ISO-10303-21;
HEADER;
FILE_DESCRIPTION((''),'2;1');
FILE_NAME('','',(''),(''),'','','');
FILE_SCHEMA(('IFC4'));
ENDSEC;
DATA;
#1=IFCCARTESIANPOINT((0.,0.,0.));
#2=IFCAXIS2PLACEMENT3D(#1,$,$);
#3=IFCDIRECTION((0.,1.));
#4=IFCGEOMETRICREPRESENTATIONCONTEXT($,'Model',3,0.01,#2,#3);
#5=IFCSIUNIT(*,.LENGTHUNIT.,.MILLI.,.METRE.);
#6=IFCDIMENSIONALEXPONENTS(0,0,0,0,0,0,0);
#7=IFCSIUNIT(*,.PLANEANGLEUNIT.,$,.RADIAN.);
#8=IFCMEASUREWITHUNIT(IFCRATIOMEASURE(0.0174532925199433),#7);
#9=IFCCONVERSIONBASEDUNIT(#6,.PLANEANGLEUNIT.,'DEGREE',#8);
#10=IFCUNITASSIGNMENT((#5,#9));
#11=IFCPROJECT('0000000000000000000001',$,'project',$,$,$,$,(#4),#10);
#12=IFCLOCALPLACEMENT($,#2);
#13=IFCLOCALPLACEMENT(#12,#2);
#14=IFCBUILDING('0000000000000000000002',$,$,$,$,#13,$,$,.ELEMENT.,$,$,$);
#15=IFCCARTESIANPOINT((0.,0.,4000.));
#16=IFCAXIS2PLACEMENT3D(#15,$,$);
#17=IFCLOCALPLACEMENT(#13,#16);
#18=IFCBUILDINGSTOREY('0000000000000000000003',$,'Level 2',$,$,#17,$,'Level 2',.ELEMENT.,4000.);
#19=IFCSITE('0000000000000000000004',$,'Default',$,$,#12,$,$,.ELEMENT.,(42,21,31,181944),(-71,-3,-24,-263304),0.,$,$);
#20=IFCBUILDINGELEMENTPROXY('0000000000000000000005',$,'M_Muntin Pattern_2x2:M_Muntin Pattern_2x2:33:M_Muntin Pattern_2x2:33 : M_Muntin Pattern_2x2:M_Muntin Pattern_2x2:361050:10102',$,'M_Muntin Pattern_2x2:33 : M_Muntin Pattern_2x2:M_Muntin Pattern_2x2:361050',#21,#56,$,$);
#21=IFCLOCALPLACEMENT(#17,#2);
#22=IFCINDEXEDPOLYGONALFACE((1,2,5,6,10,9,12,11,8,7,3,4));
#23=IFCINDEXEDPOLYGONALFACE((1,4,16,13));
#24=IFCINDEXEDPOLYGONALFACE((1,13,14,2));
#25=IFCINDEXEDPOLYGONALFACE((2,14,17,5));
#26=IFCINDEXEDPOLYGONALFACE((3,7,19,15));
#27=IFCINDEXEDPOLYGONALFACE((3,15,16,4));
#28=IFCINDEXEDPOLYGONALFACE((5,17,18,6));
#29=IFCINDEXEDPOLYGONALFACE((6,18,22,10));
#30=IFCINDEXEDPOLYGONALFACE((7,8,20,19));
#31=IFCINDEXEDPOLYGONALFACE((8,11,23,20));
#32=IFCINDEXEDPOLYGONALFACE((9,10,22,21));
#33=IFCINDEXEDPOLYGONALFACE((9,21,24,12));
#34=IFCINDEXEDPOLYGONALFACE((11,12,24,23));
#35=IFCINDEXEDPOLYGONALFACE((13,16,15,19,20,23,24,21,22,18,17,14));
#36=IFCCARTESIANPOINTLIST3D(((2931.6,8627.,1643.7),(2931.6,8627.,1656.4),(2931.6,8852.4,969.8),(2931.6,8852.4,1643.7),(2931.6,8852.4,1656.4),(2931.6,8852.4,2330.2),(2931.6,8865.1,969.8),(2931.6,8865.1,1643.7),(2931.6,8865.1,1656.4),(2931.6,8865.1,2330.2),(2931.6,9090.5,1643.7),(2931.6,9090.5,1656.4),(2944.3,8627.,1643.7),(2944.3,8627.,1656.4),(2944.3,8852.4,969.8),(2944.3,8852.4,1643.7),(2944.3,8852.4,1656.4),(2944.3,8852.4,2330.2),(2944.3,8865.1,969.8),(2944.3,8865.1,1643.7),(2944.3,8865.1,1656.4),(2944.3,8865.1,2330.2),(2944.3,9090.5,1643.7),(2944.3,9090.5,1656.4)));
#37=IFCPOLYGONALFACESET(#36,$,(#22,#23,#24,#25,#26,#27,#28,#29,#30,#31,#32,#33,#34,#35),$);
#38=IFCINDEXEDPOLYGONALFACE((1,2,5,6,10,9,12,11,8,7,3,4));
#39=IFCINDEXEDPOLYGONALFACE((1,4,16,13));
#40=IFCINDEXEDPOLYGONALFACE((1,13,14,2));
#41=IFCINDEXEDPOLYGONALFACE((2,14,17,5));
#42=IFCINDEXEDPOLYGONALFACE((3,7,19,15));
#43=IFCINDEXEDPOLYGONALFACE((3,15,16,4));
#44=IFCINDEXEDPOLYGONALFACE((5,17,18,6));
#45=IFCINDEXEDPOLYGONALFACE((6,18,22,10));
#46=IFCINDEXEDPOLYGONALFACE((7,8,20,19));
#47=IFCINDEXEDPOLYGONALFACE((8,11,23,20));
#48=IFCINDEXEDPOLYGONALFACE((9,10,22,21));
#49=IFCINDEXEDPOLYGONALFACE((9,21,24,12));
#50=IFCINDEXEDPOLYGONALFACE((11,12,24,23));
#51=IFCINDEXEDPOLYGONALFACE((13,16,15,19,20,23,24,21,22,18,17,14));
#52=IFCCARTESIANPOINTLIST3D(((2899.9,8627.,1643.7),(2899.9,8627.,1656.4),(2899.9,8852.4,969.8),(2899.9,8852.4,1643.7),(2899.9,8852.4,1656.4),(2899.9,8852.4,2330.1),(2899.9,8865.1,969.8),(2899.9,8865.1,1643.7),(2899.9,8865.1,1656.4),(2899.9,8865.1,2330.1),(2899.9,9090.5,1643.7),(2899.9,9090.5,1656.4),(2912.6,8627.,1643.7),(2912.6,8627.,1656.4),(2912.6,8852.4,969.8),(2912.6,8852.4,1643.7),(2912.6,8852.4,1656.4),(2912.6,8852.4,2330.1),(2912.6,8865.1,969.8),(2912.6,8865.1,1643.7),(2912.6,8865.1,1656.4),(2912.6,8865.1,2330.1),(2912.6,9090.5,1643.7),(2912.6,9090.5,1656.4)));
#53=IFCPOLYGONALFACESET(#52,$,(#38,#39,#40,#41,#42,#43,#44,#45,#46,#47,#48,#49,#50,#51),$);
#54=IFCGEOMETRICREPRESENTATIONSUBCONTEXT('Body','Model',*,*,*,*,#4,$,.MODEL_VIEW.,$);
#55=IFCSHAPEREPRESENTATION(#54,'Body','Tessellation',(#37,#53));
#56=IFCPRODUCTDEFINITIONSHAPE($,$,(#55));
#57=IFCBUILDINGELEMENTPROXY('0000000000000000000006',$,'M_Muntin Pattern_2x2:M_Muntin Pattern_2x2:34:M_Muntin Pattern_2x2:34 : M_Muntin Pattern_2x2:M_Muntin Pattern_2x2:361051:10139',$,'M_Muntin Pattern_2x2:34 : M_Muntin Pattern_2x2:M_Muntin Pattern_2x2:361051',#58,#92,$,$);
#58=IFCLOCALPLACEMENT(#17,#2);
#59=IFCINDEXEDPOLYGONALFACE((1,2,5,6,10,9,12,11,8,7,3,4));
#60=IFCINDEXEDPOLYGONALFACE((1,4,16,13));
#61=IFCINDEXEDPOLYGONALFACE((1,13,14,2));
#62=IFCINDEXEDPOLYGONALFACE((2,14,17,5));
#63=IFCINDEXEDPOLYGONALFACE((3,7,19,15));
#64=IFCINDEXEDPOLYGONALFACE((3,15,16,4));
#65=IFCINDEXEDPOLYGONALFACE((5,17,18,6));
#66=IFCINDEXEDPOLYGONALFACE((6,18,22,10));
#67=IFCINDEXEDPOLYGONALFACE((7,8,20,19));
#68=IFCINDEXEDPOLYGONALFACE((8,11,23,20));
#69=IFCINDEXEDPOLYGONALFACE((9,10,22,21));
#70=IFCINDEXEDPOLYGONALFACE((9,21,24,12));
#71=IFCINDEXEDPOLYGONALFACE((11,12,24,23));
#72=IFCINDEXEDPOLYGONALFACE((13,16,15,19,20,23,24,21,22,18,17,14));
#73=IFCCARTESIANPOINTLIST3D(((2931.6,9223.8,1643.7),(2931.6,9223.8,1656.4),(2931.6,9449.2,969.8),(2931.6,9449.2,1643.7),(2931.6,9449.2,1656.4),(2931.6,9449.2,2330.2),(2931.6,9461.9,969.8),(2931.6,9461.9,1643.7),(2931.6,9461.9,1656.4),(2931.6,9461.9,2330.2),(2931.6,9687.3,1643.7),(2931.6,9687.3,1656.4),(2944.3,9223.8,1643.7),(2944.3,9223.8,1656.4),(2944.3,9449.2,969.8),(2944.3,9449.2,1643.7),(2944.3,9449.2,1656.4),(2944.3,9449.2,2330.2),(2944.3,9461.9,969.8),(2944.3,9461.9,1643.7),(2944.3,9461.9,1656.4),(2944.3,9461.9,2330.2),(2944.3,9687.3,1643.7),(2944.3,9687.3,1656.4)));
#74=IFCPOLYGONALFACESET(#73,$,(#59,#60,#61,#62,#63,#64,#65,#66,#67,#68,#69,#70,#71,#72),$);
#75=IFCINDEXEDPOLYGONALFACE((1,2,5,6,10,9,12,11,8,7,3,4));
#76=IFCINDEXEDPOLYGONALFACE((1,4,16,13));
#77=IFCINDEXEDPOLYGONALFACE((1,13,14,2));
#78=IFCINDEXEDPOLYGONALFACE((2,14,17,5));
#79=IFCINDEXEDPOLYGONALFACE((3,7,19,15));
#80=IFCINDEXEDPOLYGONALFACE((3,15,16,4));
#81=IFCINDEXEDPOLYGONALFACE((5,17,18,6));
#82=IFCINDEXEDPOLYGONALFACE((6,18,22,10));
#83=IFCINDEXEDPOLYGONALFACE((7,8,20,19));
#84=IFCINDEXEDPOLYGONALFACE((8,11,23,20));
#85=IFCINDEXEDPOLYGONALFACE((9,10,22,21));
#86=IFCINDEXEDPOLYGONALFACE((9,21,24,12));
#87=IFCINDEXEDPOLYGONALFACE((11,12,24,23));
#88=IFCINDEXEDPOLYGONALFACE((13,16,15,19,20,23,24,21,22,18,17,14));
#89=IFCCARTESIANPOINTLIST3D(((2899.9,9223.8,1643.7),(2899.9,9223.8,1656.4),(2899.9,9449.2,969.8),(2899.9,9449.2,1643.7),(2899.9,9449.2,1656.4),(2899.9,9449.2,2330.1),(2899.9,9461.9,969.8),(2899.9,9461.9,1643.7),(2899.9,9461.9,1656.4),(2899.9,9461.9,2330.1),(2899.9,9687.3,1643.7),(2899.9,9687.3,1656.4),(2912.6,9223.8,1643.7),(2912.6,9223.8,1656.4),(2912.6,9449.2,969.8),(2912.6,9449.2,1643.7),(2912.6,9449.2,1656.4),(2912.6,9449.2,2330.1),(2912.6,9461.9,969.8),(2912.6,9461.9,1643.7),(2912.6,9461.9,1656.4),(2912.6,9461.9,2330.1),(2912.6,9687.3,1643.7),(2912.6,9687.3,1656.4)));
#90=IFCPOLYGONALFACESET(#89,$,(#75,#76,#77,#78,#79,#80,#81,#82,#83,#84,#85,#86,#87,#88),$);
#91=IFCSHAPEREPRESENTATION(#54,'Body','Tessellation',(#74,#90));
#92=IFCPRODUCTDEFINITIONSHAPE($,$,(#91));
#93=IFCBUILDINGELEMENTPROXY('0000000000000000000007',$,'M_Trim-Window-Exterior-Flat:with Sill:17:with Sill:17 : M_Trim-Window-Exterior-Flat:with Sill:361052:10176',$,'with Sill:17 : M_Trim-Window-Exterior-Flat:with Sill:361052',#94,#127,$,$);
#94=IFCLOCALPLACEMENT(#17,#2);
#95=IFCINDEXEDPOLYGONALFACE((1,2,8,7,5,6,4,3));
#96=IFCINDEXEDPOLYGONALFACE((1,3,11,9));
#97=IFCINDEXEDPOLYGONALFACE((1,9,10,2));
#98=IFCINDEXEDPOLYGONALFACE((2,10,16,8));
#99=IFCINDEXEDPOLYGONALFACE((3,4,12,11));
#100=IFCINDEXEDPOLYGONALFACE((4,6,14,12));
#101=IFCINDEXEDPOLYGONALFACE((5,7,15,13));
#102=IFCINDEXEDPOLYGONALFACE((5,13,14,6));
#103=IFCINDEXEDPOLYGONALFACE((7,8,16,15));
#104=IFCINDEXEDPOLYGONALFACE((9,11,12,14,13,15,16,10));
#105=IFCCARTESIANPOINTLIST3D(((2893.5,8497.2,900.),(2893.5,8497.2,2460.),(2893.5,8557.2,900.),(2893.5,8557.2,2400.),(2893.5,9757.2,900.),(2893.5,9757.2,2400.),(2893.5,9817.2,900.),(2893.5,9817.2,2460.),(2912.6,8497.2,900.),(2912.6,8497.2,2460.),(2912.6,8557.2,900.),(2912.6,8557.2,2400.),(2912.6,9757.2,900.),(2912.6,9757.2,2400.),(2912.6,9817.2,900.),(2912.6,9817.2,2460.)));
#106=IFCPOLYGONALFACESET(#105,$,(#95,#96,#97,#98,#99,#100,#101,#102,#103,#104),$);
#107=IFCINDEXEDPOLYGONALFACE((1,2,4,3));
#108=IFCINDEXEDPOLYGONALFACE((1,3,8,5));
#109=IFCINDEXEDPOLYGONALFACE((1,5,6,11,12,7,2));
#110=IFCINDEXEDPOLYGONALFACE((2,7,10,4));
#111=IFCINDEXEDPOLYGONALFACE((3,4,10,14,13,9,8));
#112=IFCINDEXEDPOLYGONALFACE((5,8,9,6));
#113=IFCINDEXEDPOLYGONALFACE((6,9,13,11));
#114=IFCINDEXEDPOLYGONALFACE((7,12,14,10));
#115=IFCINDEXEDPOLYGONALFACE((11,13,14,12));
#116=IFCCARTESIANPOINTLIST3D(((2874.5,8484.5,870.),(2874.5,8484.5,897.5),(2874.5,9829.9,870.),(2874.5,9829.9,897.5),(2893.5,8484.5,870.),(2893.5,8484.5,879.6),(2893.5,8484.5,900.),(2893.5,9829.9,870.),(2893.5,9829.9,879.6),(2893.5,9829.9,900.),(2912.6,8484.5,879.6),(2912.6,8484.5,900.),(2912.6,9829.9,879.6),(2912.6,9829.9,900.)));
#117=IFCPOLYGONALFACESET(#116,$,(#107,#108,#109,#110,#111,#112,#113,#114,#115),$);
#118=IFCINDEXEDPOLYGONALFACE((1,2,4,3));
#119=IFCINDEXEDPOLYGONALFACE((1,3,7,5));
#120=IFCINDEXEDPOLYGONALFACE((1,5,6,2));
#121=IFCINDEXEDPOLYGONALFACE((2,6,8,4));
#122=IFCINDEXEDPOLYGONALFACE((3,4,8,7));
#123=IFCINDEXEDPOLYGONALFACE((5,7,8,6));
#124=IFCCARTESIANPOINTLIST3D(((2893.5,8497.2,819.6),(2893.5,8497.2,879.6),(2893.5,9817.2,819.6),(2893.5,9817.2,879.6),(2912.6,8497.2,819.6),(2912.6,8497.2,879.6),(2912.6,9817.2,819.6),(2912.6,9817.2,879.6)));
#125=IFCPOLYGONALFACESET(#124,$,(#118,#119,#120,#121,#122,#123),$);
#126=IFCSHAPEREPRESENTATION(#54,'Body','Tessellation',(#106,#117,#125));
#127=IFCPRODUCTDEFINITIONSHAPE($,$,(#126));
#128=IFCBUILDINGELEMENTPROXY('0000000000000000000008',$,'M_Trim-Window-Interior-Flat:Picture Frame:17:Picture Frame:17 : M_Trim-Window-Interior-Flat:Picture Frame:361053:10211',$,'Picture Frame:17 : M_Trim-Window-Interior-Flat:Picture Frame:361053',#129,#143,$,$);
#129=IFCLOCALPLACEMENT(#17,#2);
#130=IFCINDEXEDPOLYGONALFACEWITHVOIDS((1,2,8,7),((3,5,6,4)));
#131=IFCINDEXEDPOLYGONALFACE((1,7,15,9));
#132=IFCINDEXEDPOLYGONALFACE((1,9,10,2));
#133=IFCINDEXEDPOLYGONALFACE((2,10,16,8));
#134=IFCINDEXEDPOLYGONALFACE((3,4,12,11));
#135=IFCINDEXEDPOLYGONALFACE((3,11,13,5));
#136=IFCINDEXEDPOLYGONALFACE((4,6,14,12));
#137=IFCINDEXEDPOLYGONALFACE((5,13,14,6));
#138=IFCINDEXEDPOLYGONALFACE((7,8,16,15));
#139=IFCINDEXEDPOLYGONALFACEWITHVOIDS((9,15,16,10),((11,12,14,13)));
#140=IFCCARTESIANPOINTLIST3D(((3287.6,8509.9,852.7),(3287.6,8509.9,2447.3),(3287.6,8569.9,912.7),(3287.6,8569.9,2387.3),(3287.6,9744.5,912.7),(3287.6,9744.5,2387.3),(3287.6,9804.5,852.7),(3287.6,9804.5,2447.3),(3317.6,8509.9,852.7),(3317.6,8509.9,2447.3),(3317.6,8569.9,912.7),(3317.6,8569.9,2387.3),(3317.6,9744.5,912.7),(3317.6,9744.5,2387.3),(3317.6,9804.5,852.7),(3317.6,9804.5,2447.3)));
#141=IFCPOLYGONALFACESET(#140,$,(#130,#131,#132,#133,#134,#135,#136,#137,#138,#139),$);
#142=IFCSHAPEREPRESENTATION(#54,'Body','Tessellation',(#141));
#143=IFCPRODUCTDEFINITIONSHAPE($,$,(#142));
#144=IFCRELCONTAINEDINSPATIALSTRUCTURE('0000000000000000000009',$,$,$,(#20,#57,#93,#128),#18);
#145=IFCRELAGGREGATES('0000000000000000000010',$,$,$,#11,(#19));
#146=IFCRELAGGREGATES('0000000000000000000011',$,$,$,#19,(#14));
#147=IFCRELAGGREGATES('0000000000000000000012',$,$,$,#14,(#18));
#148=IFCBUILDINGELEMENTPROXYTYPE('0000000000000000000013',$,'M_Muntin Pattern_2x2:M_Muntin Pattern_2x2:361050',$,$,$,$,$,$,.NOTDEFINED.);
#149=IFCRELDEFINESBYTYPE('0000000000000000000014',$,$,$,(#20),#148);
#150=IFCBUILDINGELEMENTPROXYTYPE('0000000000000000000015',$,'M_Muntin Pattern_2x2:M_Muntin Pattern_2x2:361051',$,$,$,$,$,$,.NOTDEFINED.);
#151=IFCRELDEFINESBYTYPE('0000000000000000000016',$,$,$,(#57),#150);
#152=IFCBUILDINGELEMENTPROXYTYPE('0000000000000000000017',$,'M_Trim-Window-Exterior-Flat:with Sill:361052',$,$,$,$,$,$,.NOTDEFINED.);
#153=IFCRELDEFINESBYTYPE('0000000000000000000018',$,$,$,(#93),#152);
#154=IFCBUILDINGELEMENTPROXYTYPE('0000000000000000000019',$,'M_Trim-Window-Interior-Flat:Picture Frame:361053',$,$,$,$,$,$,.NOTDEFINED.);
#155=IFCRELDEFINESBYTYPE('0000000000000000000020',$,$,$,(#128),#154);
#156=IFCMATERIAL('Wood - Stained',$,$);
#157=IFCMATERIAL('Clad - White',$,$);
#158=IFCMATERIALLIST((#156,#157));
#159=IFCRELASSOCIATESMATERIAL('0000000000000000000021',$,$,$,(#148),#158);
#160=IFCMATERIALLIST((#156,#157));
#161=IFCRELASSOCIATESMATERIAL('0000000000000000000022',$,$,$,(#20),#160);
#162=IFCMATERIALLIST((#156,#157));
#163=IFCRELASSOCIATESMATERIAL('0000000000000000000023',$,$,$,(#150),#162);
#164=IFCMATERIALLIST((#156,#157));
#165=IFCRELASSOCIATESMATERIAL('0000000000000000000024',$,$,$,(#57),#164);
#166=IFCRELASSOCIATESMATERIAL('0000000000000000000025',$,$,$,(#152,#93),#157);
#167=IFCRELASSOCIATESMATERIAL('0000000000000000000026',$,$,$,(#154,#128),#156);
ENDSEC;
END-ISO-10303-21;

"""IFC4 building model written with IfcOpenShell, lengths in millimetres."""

from ifc_helpers import new_model, entity, si_unit, converted_unit, direction, frame, frame_2d, origin, place, context, subcontext, project, spatial, polyline, rectangle, outline, extrude, source, transform, mapped, material, material_list, type_object, type_shapes, element, save


model = new_model("IFC4")

# Units and contexts
model_context = context("Model", 3, precision=0.01, world=origin(), true_north=direction((0.0, 1.0)))
body_context = subcontext(model_context, "Body", "Model", "MODEL_VIEW")
ifc_project = project(units=[si_unit("LENGTHUNIT", "METRE", prefix="MILLI"), converted_unit("PLANEANGLEUNIT", "DEGREE", entity("IfcRatioMeasure", 0.0174532925199433), si_unit("PLANEANGLEUNIT", "RADIAN"), dimensions=[0, 0, 0, 0, 0, 0, 0])], contexts=[model_context])

# Site, building, storey
site_placement = place(None, origin())
site = spatial("IfcSite", under=ifc_project, at=site_placement, Name="Default", CompositionType="ELEMENT", RefLatitude=(42, 21, 31, 181944), RefLongitude=(-71, -3, -24, -263304), RefElevation=0.0)
building_placement = place(site_placement, origin())
building = spatial("IfcBuilding", under=site, at=building_placement, CompositionType="ELEMENT")
storey_placement = place(building_placement, frame((0.0, 0.0, 4000.0)))
storey = spatial("IfcBuildingStorey", under=building, at=storey_placement, Name="Level 2", LongName="Level 2", CompositionType="ELEMENT", Elevation=4000.0)

# Building element proxies
ifc_material_1 = material(Name="Wood - Stained")
ifc_material_2 = material(Name="Clad - White")
ifc_material_list_1 = material_list([ifc_material_1, ifc_material_2])
ifc_material_list_2 = material_list([ifc_material_1, ifc_material_2])
building_element_proxy_type_1 = type_object("IfcBuildingElementProxyType", Name="M_Muntin Pattern_2x2:M_Muntin Pattern_2x2:361050", PredefinedType="NOTDEFINED", material=ifc_material_list_2)
shared_shape_1 = source(origin(), body_context, "Body", "SweptSolid", [
    extrude(outline(polyline([(-680.2, 6.4), (-680.2, -6.3), (-6.4, -6.3), (-6.4, -231.7), (6.3, -231.7), (6.3, -6.3), (680.2, -6.3), (680.2, 6.4), (6.3, 6.4), (6.3, 231.7), (-6.4, 231.7), (-6.4, 6.4), (-680.2, 6.4)])), frame((2931.6, 8858.7, 5650.0), z_axis=(-1.0, 0.0, 0.0), x_axis=(0.0, 0.0, -1.0)), (0.0, 0.0, -1.0), 12.7),
    extrude(outline(polyline([(-680.1, 6.4), (-680.1, -6.3), (-6.4, -6.3), (-6.4, -231.7), (6.3, -231.7), (6.3, -6.3), (680.2, -6.3), (680.2, 6.4), (6.3, 6.4), (6.3, 231.7), (-6.4, 231.7), (-6.4, 6.4), (-680.1, 6.4)])), frame((2899.9, 8858.7, 5650.0), z_axis=(-1.0, 0.0, 0.0), x_axis=(0.0, 0.0, -1.0)), (0.0, 0.0, -1.0), 12.7),
])
type_shapes(building_element_proxy_type_1, [shared_shape_1])
proxy_1_placement = place(storey_placement, frame((0.0, 0.0, -4000.0)))
element("IfcBuildingElementProxy", 1, at=proxy_1_placement, inside=storey, type_object=building_element_proxy_type_1, material=ifc_material_list_1, Name="M_Muntin Pattern_2x2:M_Muntin Pattern_2x2:33:M_Muntin Pattern_2x2:33 : M_Muntin Pattern_2x2:M_Muntin Pattern_2x2:361050:10102", ObjectType="M_Muntin Pattern_2x2:33 : M_Muntin Pattern_2x2:M_Muntin Pattern_2x2:361050", context=body_context, shape_type="MappedRepresentation", body=[
    mapped(shared_shape_1, transform((0.0, 0.0, 0.0), scale=1.0)),
])
ifc_material_list_3 = material_list([ifc_material_1, ifc_material_2])
ifc_material_list_4 = material_list([ifc_material_1, ifc_material_2])
building_element_proxy_type_2 = type_object("IfcBuildingElementProxyType", Name="M_Muntin Pattern_2x2:M_Muntin Pattern_2x2:361051", PredefinedType="NOTDEFINED", material=ifc_material_list_4)
shared_shape_2 = source(origin(), body_context, "Body", "SweptSolid", [
    extrude(outline(polyline([(-6.4, -680.1), (6.3, -680.1), (6.3, -6.4), (231.7, -6.4), (231.7, 6.3), (6.3, 6.3), (6.3, 680.2), (-6.4, 680.2), (-6.4, 6.3), (-231.7, 6.3), (-231.7, -6.4), (-6.4, -6.4), (-6.4, -680.1)])), frame((2931.6, 9455.6, 5650.0), z_axis=(1.0, 0.0, 0.0), x_axis=(0.0, -1.0, 0.0)), (0.0, 0.0, 1.0), 12.7),
    extrude(outline(polyline([(-6.4, -680.1), (6.3, -680.1), (6.3, -6.4), (231.7, -6.4), (231.7, 6.3), (6.3, 6.3), (6.3, 680.2), (-6.4, 680.2), (-6.4, 6.3), (-231.7, 6.3), (-231.7, -6.4), (-6.4, -6.4), (-6.4, -680.1)])), frame((2899.9, 9455.6, 5650.0), z_axis=(1.0, 0.0, 0.0), x_axis=(0.0, -1.0, 0.0)), (0.0, 0.0, 1.0), 12.7),
])
type_shapes(building_element_proxy_type_2, [shared_shape_2])
proxy_2_placement = place(storey_placement, frame((0.0, 0.0, -4000.0)))
element("IfcBuildingElementProxy", 2, at=proxy_2_placement, inside=storey, type_object=building_element_proxy_type_2, material=ifc_material_list_3, Name="M_Muntin Pattern_2x2:M_Muntin Pattern_2x2:34:M_Muntin Pattern_2x2:34 : M_Muntin Pattern_2x2:M_Muntin Pattern_2x2:361051:10139", ObjectType="M_Muntin Pattern_2x2:34 : M_Muntin Pattern_2x2:M_Muntin Pattern_2x2:361051", context=body_context, shape_type="MappedRepresentation", body=[
    mapped(shared_shape_2, transform((0.0, 0.0, 0.0), scale=1.0)),
])
building_element_proxy_type_3 = type_object("IfcBuildingElementProxyType", Name="M_Trim-Window-Exterior-Flat:with Sill:361052", PredefinedType="NOTDEFINED", material=ifc_material_2)
shared_shape_3 = source(origin(), body_context, "Body", "SweptSolid", [
    extrude(outline(polyline([(-765.0, -660.0), (795.0, -660.0), (795.0, 660.0), (-765.0, 660.0), (-765.0, 600.0), (735.0, 600.0), (735.0, -600.0), (-765.0, -600.0), (-765.0, -660.0)])), frame((2893.5, 9157.2, 5665.0), z_axis=(1.0, 0.0, 0.0), x_axis=(0.0, 0.0, 1.0)), (0.0, 0.0, 1.0), 19.1),
    extrude(outline(polyline([(0.0, -15.2), (19.0, -15.2), (19.0, 12.3), (0.0, 14.8), (-19.0, 14.8), (-19.0, -5.7), (0.0, -5.7), (0.0, -15.2)])), frame((2893.5, 8484.5, 4885.2), z_axis=(0.0, 1.0, 0.0), x_axis=(-1.0, 0.0, 0.0)), (0.0, 0.0, 1.0), 1345.4),
    extrude(rectangle(XDim=19.1, YDim=1320.0, at=frame_2d((0.0, 0.0), x_axis=(1.0, 0.0))), frame((2903.0, 9157.2, 4819.6)), (0.0, 0.0, 1.0), 60.0),
])
type_shapes(building_element_proxy_type_3, [shared_shape_3])
proxy_3_placement = place(storey_placement, frame((0.0, 0.0, -4000.0)))
element("IfcBuildingElementProxy", 3, at=proxy_3_placement, inside=storey, type_object=building_element_proxy_type_3, material=ifc_material_2, Name="M_Trim-Window-Exterior-Flat:with Sill:17:with Sill:17 : M_Trim-Window-Exterior-Flat:with Sill:361052:10176", ObjectType="with Sill:17 : M_Trim-Window-Exterior-Flat:with Sill:361052", context=body_context, shape_type="MappedRepresentation", body=[
    mapped(shared_shape_3, transform((0.0, 0.0, 0.0), scale=1.0)),
])
building_element_proxy_type_4 = type_object("IfcBuildingElementProxyType", Name="M_Trim-Window-Interior-Flat:Picture Frame:361053", PredefinedType="NOTDEFINED", material=ifc_material_1)
shared_shape_4 = source(origin(), body_context, "Body", "SweptSolid", [
    extrude(outline(polyline([(-797.3, -647.3), (797.3, -647.3), (797.3, 647.3), (-797.3, 647.3), (-797.3, -647.3)]), holes=[polyline([(737.3, 587.3), (737.3, -587.3), (-737.3, -587.3), (-737.3, 587.3), (737.3, 587.3)])]), frame((3287.6, 9157.2, 5650.0), z_axis=(1.0, 0.0, 0.0), x_axis=(0.0, 0.0, -1.0)), (0.0, 0.0, 1.0), 30.0),
])
type_shapes(building_element_proxy_type_4, [shared_shape_4])
proxy_4_placement = place(storey_placement, frame((0.0, 0.0, -4000.0)))
element("IfcBuildingElementProxy", 4, at=proxy_4_placement, inside=storey, type_object=building_element_proxy_type_4, material=ifc_material_1, Name="M_Trim-Window-Interior-Flat:Picture Frame:17:Picture Frame:17 : M_Trim-Window-Interior-Flat:Picture Frame:361053:10211", ObjectType="Picture Frame:17 : M_Trim-Window-Interior-Flat:Picture Frame:361053", context=body_context, shape_type="MappedRepresentation", body=[
    mapped(shared_shape_4, transform((0.0, 0.0, 0.0), scale=1.0)),
])

save(model, "model.ifc")
